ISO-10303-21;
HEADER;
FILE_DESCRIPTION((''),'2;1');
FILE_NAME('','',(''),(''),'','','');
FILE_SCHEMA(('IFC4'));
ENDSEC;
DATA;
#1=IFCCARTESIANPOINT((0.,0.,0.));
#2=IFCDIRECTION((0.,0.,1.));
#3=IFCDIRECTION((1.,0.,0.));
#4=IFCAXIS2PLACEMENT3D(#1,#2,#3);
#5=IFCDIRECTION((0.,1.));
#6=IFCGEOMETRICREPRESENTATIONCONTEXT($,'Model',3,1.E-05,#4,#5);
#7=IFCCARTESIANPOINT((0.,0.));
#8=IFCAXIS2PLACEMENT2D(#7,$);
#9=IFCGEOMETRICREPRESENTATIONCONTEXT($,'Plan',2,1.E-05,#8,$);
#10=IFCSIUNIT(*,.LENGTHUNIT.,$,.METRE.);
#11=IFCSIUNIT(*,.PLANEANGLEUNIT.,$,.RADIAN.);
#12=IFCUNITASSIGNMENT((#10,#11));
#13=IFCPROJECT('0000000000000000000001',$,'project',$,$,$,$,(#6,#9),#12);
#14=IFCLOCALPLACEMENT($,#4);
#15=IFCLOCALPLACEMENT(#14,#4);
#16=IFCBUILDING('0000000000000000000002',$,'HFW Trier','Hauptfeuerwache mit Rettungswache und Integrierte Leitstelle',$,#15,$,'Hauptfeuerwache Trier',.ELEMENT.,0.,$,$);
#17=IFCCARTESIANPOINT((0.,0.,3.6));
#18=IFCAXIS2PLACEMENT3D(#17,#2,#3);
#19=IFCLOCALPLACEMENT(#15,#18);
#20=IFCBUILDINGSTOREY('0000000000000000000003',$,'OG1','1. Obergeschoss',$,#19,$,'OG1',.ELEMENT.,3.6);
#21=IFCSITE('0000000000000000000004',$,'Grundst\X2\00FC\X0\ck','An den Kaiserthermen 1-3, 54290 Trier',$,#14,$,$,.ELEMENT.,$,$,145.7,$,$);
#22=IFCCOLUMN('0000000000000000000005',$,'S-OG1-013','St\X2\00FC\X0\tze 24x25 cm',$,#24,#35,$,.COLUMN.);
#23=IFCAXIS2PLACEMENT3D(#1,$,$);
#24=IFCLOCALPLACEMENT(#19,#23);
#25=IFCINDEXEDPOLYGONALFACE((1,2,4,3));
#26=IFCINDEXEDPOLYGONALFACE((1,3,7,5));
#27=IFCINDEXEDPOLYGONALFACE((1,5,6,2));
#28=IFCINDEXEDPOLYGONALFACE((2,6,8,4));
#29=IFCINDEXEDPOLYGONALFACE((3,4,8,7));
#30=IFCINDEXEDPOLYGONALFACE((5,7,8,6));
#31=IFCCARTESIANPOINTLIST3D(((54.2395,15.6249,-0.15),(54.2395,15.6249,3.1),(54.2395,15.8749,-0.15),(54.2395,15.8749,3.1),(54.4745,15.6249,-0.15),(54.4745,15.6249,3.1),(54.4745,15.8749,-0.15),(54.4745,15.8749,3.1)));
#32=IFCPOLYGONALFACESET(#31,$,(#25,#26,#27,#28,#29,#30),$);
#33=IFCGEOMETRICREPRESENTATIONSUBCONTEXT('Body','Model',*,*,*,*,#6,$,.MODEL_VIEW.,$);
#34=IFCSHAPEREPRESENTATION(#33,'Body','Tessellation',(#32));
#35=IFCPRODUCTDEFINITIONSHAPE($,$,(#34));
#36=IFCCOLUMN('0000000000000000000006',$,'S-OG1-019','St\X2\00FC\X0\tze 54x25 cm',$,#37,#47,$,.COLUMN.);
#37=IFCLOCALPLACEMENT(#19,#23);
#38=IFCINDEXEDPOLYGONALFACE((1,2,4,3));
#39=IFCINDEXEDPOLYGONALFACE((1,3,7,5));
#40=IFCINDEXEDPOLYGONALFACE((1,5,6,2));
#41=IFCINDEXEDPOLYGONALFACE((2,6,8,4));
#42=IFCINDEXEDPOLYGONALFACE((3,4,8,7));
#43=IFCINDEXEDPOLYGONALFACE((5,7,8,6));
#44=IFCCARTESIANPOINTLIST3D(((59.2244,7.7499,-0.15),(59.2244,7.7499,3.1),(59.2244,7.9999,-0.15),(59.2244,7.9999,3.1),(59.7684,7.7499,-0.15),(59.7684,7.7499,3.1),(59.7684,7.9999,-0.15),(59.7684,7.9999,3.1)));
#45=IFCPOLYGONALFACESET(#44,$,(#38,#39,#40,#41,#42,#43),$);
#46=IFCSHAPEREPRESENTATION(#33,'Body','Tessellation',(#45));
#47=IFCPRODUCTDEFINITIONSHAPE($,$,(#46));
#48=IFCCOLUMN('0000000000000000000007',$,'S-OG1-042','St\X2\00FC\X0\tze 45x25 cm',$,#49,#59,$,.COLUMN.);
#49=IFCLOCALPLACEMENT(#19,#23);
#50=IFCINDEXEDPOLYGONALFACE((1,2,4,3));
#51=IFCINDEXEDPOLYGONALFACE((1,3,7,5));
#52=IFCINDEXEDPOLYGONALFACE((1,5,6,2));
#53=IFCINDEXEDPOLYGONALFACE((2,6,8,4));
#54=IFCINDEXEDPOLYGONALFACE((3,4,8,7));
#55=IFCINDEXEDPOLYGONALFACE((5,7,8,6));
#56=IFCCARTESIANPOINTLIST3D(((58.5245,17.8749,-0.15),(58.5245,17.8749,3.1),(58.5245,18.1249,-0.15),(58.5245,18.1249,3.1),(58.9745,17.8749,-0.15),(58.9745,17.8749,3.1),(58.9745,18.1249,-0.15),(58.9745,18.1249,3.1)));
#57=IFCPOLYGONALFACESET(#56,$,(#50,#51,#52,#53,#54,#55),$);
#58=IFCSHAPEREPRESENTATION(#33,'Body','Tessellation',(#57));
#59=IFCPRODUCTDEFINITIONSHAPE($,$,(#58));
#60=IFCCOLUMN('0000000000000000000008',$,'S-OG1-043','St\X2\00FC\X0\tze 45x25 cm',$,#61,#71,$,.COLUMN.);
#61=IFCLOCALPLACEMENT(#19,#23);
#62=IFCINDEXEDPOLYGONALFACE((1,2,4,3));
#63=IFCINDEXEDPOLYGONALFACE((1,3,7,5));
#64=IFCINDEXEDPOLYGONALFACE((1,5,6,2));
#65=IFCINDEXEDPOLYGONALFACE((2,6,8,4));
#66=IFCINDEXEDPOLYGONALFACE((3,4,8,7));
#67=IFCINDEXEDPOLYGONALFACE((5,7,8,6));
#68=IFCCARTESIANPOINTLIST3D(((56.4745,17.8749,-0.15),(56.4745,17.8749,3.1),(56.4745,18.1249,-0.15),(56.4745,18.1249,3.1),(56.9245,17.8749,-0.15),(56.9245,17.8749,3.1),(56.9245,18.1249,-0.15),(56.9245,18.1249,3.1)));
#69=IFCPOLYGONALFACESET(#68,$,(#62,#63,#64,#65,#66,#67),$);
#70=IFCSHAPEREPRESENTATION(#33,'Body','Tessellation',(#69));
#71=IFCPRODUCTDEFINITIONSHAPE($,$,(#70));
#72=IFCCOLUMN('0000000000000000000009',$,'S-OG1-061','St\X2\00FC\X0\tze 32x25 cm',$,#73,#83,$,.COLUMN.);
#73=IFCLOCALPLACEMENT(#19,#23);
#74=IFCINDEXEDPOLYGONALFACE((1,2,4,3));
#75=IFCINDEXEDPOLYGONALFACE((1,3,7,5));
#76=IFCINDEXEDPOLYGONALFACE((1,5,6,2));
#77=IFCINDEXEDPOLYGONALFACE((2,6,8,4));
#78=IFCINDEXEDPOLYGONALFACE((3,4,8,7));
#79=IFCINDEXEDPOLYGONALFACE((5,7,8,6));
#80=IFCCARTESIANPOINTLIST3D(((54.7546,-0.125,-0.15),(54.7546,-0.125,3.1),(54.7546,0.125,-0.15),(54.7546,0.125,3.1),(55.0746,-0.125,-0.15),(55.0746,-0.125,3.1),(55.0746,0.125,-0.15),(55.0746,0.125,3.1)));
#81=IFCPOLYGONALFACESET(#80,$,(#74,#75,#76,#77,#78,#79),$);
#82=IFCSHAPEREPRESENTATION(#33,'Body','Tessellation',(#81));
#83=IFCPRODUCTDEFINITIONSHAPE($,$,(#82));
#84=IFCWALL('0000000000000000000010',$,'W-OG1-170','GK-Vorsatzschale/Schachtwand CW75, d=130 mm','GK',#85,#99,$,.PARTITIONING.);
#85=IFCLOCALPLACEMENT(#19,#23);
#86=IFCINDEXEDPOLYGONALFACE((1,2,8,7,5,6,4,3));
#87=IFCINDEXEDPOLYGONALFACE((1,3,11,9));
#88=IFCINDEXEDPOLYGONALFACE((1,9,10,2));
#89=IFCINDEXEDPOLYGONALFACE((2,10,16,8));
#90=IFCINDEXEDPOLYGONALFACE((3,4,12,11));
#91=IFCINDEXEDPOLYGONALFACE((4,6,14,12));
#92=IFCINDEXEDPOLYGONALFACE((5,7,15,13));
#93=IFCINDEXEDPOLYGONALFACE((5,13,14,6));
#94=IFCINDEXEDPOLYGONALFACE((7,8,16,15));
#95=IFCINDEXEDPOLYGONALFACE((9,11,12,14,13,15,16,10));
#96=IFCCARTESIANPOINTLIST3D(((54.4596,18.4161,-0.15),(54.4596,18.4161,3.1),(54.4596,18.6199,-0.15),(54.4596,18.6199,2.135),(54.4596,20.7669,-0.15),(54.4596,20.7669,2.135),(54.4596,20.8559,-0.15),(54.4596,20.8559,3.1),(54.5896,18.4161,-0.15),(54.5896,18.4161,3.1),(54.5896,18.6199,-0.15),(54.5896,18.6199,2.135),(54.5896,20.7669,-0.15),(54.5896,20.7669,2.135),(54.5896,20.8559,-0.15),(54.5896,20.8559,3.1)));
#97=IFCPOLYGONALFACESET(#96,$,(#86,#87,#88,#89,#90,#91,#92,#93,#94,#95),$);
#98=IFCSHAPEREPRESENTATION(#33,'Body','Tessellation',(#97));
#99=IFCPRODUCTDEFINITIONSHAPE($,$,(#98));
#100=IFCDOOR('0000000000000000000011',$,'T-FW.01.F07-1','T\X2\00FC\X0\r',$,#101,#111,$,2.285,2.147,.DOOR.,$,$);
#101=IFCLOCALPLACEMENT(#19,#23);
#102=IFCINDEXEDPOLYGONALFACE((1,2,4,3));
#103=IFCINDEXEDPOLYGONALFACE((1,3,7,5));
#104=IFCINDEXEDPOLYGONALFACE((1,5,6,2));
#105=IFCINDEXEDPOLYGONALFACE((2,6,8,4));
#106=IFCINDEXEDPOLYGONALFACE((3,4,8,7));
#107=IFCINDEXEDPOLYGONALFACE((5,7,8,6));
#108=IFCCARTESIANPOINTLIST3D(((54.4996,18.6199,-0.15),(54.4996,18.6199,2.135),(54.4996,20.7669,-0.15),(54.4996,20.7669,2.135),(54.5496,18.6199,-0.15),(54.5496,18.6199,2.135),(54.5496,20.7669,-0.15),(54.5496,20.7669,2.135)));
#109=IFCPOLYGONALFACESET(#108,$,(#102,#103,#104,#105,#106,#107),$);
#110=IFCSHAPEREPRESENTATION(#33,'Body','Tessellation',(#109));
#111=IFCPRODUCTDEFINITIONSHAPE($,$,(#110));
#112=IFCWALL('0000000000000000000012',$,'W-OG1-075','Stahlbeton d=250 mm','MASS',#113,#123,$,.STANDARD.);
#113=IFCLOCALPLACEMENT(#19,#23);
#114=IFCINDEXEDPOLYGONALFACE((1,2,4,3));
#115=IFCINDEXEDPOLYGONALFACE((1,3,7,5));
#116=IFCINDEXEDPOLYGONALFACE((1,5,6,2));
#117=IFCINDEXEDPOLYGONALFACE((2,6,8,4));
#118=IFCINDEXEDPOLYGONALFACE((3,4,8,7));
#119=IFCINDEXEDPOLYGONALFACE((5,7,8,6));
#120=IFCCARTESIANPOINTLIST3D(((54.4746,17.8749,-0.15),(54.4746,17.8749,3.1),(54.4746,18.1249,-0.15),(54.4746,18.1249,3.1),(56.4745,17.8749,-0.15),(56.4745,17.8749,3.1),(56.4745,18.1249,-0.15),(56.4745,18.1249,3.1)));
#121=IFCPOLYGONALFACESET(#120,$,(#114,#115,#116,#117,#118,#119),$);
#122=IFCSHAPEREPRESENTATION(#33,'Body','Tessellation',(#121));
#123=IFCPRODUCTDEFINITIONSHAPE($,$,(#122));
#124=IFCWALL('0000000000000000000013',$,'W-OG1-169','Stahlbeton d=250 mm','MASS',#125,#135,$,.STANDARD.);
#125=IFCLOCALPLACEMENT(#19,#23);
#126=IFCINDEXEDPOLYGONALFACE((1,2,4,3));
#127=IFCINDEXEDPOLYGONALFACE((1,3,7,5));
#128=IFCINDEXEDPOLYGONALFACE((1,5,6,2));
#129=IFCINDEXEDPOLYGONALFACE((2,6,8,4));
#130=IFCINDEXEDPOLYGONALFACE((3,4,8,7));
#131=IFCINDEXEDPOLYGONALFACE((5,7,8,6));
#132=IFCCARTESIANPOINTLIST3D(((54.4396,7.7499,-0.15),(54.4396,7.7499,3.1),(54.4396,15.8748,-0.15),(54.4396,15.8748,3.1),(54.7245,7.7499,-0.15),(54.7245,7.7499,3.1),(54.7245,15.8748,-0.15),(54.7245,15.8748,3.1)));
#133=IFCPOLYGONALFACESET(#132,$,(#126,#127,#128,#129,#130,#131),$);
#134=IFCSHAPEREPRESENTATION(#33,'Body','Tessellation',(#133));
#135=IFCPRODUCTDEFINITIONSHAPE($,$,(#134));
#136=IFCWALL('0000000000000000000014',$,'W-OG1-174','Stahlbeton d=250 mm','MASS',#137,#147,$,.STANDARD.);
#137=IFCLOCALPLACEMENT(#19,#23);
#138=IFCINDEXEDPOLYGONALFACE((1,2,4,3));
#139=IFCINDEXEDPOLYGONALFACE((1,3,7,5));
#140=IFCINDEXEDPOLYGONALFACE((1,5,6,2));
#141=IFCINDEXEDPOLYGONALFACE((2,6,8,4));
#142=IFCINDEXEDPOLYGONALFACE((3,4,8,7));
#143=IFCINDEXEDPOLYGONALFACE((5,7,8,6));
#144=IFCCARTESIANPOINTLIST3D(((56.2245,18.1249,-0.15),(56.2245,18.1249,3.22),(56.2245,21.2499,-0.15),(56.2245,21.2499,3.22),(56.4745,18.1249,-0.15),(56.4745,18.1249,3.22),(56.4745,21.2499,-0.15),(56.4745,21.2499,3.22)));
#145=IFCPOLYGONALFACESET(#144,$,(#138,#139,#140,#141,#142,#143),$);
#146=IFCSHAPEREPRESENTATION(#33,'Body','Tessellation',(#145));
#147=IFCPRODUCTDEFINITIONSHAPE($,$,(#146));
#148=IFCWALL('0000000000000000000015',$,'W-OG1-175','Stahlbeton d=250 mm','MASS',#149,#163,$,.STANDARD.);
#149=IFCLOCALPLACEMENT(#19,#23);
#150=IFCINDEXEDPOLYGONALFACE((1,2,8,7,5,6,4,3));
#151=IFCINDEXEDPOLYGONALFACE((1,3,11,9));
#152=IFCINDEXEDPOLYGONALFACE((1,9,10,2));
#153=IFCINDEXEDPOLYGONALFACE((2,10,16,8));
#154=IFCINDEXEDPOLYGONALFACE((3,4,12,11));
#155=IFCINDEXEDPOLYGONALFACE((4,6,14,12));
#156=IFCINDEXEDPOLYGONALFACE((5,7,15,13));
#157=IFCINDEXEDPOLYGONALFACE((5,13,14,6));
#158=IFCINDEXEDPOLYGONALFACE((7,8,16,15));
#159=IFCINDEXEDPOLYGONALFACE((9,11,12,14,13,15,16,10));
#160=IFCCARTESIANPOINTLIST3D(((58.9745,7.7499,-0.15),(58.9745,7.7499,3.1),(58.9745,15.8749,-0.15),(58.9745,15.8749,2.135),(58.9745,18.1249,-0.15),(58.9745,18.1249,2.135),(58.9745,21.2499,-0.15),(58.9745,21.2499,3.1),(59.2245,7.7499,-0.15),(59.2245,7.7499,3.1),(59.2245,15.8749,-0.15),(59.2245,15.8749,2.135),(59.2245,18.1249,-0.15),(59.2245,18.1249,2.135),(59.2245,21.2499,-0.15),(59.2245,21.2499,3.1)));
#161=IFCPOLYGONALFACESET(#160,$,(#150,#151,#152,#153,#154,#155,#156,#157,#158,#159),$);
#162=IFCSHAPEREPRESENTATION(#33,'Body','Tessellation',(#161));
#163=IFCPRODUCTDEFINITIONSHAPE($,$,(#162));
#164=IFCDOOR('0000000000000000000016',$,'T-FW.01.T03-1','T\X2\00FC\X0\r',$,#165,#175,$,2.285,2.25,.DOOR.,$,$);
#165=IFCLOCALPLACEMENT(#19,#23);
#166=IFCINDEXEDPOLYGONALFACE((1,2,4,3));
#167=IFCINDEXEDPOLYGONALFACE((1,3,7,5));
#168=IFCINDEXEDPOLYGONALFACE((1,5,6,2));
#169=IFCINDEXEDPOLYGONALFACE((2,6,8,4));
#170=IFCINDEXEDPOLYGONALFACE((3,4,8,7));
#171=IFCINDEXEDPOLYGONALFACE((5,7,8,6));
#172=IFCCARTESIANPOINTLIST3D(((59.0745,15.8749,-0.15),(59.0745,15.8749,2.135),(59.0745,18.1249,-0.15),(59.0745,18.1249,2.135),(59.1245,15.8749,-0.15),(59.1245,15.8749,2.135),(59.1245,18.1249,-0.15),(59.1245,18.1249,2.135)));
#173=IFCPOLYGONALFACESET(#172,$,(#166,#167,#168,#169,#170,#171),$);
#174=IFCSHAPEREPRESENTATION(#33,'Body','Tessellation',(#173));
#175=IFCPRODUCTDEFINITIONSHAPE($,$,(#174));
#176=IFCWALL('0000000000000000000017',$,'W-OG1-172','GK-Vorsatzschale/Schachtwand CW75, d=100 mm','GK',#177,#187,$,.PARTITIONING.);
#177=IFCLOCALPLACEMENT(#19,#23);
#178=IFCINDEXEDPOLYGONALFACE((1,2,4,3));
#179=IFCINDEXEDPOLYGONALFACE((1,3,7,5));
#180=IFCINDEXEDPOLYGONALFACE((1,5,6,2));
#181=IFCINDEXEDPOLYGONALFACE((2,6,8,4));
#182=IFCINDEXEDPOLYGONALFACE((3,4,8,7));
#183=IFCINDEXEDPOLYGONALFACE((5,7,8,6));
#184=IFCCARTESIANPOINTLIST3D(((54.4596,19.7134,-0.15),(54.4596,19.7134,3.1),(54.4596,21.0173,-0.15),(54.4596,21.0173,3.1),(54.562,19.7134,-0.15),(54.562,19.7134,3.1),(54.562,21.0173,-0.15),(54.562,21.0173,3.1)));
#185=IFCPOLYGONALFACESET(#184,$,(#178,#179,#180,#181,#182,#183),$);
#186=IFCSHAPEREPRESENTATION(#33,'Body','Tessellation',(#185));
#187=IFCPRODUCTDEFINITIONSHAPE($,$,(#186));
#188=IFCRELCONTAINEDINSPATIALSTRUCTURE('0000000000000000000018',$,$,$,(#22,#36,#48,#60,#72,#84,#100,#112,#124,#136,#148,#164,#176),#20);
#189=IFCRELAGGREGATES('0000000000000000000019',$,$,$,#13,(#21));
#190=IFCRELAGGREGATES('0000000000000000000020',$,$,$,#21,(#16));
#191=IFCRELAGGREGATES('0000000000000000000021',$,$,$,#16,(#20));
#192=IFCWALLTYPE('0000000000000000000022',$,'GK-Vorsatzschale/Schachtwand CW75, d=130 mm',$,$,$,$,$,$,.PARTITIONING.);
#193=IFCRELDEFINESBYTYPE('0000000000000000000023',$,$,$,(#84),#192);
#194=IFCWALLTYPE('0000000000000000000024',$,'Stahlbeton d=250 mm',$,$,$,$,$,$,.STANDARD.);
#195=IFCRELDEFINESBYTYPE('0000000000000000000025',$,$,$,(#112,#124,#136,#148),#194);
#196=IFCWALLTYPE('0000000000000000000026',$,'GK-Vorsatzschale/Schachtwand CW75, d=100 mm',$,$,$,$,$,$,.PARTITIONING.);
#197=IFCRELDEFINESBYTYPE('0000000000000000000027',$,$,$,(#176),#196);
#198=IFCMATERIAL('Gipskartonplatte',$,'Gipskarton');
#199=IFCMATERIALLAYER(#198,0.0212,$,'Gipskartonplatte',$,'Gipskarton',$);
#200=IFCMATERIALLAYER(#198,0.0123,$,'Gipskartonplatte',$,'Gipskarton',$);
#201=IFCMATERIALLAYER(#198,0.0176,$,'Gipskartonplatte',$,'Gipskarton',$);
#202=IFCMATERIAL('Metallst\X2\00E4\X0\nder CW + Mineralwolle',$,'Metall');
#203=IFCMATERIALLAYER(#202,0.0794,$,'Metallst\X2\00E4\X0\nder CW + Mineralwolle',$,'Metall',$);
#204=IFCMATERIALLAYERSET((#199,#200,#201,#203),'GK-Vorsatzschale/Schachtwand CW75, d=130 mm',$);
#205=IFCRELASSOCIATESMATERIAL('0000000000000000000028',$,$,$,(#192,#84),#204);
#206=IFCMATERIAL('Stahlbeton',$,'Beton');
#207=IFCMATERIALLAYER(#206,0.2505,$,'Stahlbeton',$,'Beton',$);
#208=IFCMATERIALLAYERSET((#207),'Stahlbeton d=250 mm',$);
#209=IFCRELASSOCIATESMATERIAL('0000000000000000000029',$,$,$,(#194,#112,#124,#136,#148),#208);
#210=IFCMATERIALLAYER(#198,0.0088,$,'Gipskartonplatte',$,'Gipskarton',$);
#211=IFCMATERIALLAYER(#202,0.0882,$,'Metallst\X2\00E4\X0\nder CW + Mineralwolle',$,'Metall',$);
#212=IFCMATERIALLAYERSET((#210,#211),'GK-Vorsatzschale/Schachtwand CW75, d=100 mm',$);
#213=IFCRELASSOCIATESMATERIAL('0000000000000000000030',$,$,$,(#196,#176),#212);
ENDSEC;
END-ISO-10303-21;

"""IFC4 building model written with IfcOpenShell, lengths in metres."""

from ifc_helpers import new_model, si_unit, direction, frame, frame_2d, origin_with_axes, origin_2d, place, context, subcontext, project, spatial, rectangle, extrude, material, layer, layer_set, layer_usage, type_object, element, fill, save


model = new_model("IFC4")

# Units and contexts
model_context = context("Model", 3, precision=1e-05, world=origin_with_axes(), true_north=direction((0.0, 1.0)))
plan_context = context("Plan", 2, precision=1e-05, world=origin_2d())
body_context = subcontext(model_context, "Body", "Model", "MODEL_VIEW")
ifc_project = project(units=[si_unit("LENGTHUNIT", "METRE"), si_unit("PLANEANGLEUNIT", "RADIAN")], contexts=[model_context, plan_context])

# Site, building, storey
site_placement = place(None, origin_with_axes())
site = spatial("IfcSite", under=ifc_project, at=site_placement, Name="Grundstück", Description="An den Kaiserthermen 1-3, 54290 Trier", CompositionType="ELEMENT", RefElevation=145.7)
building_placement = place(site_placement, origin_with_axes())
building = spatial("IfcBuilding", under=site, at=building_placement, Name="HFW Trier", Description="Hauptfeuerwache mit Rettungswache und Integrierte Leitstelle", LongName="Hauptfeuerwache Trier", CompositionType="ELEMENT", ElevationOfRefHeight=0.0)
storey_placement = place(building_placement, frame((0.0, 0.0, 3.6), z_axis=(0.0, 0.0, 1.0), x_axis=(1.0, 0.0, 0.0)))
storey = spatial("IfcBuildingStorey", under=building, at=storey_placement, Name="OG1", Description="1. Obergeschoss", LongName="OG1", CompositionType="ELEMENT", Elevation=3.6)

# Columns
column_1_placement = place(storey_placement, frame((54.2395, 15.7499, -0.15), z_axis=(0.0, 0.0, 1.0), x_axis=(1.0, 0.0, 0.0)))
element("IfcColumn", 1, at=column_1_placement, inside=storey, Name="S-OG1-013", Description="Stütze 24x25 cm", PredefinedType="COLUMN", context=body_context, shape_type="SweptSolid", body=[
    extrude(rectangle(XDim=0.235, YDim=0.25, at=frame_2d((0.1175, 0.0))), origin_with_axes(), (0.0, 0.0, 1.0), 3.25),
])
column_2_placement = place(storey_placement, frame((59.2244, 7.8749, -0.15), z_axis=(0.0, 0.0, 1.0), x_axis=(1.0, 0.0, 0.0)))
element("IfcColumn", 2, at=column_2_placement, inside=storey, Name="S-OG1-019", Description="Stütze 54x25 cm", PredefinedType="COLUMN", context=body_context, shape_type="SweptSolid", body=[
    extrude(rectangle(XDim=0.544, YDim=0.25, at=frame_2d((0.272, 0.0))), origin_with_axes(), (0.0, 0.0, 1.0), 3.25),
])
for number, where, z_axis, x_axis, name in (
    (3, (58.5245, 17.9999, -0.15), (0.0, 0.0, 1.0), (1.0, 0.0, 0.0), "S-OG1-042"),
    (4, (56.4745, 17.9999, -0.15), (0.0, 0.0, 1.0), (1.0, 0.0, 0.0), "S-OG1-043"),
):
    element("IfcColumn", number, at=place(storey_placement, frame(where, z_axis=z_axis, x_axis=x_axis)), inside=storey, Name=name, Description="Stütze 45x25 cm", PredefinedType="COLUMN", context=body_context, shape_type="SweptSolid", body=[
        extrude(rectangle(XDim=0.45, YDim=0.25, at=frame_2d((0.225, 0.0))), origin_with_axes(), (0.0, 0.0, 1.0), 3.25),
    ])
column_3_placement = place(storey_placement, frame((54.7546, 0.0, -0.15), z_axis=(0.0, 0.0, 1.0), x_axis=(1.0, 0.0, 0.0)))
element("IfcColumn", 5, at=column_3_placement, inside=storey, Name="S-OG1-061", Description="Stütze 32x25 cm", PredefinedType="COLUMN", context=body_context, shape_type="SweptSolid", body=[
    extrude(rectangle(XDim=0.32, YDim=0.25, at=frame_2d((0.16, 0.0))), origin_with_axes(), (0.0, 0.0, 1.0), 3.25),
])

# Wall, opening, door
ifc_material_1 = material(Name="Gipskartonplatte", Category="Gipskarton")
ifc_layer_1 = layer(ifc_material_1, 0.0212, Name="Gipskartonplatte", Category="Gipskarton")
ifc_layer_2 = layer(ifc_material_1, 0.0123, Name="Gipskartonplatte", Category="Gipskarton")
ifc_layer_3 = layer(ifc_material_1, 0.0176, Name="Gipskartonplatte", Category="Gipskarton")
ifc_material_2 = material(Name="Metallständer CW + Mineralwolle", Category="Metall")
ifc_layer_4 = layer(ifc_material_2, 0.0794, Name="Metallständer CW + Mineralwolle", Category="Metall")
ifc_layer_set_1 = layer_set([ifc_layer_1, ifc_layer_2, ifc_layer_3, ifc_layer_4], Name="GK-Vorsatzschale/Schachtwand CW75, d=130 mm")
ifc_layer_usage_1 = layer_usage(ifc_layer_set_1, "AXIS2", "POSITIVE", -0.065)
wall_type_1 = type_object("IfcWallType", Name="GK-Vorsatzschale/Schachtwand CW75, d=130 mm", PredefinedType="PARTITIONING", material=ifc_layer_set_1)
wall_1_placement = place(storey_placement, frame((54.5246, 20.8559, -0.15), z_axis=(0.0, 0.0, 1.0), x_axis=(0.0, -1.0, 0.0)))
wall_1 = element("IfcWall", 6, at=wall_1_placement, inside=storey, type_object=wall_type_1, material=ifc_layer_usage_1, Name="W-OG1-170", Description="GK-Vorsatzschale/Schachtwand CW75, d=130 mm", ObjectType="GK", PredefinedType="PARTITIONING", context=body_context, shape_type="SweptSolid", body=[
    extrude(rectangle(XDim=2.4398, YDim=0.13, at=frame_2d((1.2199, 0.0))), origin_with_axes(), (0.0, 0.0, 1.0), 3.25),
])
opening_1_placement = place(wall_1_placement, frame((0.089, 0.0, 0.0), z_axis=(0.0, 0.0, 1.0), x_axis=(1.0, 0.0, 0.0)))
opening_1 = element("IfcOpeningElement", 7, at=opening_1_placement, cuts=wall_1, PredefinedType="OPENING", context=body_context, shape_type="SweptSolid", body=[
    extrude(rectangle(XDim=2.147, YDim=0.23, at=frame_2d((1.0735, 0.0))), origin_with_axes(), (0.0, 0.0, 1.0), 2.285),
])
door_1_placement = place(wall_1_placement, frame((0.089, 0.0, 0.0), z_axis=(0.0, 0.0, 1.0), x_axis=(1.0, 0.0, 0.0)))
door_1 = element("IfcDoor", 8, at=door_1_placement, inside=storey, Name="T-FW.01.F07-1", Description="Tür", OverallHeight=2.285, OverallWidth=2.147, PredefinedType="DOOR", context=body_context, shape_type="SweptSolid", body=[
    extrude(rectangle(XDim=2.147, YDim=0.05, at=frame_2d((1.0735, 0.0))), origin_with_axes(), (0.0, 0.0, 1.0), 2.285),
])
fill(opening_1, door_1)

# Walls
ifc_material_3 = material(Name="Stahlbeton", Category="Beton")
ifc_layer_5 = layer(ifc_material_3, 0.2505, Name="Stahlbeton", Category="Beton")
ifc_layer_set_2 = layer_set([ifc_layer_5], Name="Stahlbeton d=250 mm")
ifc_layer_usage_2 = layer_usage(ifc_layer_set_2, "AXIS2", "POSITIVE", -0.125)
wall_type_2 = type_object("IfcWallType", Name="Stahlbeton d=250 mm", PredefinedType="STANDARD", material=ifc_layer_set_2)
wall_2_placement = place(storey_placement, frame((54.4746, 17.9999, -0.15), z_axis=(0.0, 0.0, 1.0), x_axis=(1.0, 0.0, 0.0)))
element("IfcWall", 9, at=wall_2_placement, inside=storey, type_object=wall_type_2, material=ifc_layer_usage_2, Name="W-OG1-075", Description="Stahlbeton d=250 mm", ObjectType="MASS", PredefinedType="STANDARD", context=body_context, shape_type="SweptSolid", body=[
    extrude(rectangle(XDim=1.9999, YDim=0.25, at=frame_2d((0.9999, 0.0))), origin_with_axes(), (0.0, 0.0, 1.0), 3.25),
])
ifc_layer_usage_3 = layer_usage(ifc_layer_set_2, "AXIS2", "POSITIVE", -0.1424)
wall_3_placement = place(storey_placement, frame((54.5821, 15.8748, -0.15), z_axis=(0.0, 0.0, 1.0), x_axis=(0.0, -1.0, 0.0)))
element("IfcWall", 10, at=wall_3_placement, inside=storey, type_object=wall_type_2, material=ifc_layer_usage_3, Name="W-OG1-169", Description="Stahlbeton d=250 mm", ObjectType="MASS", PredefinedType="STANDARD", context=body_context, shape_type="SweptSolid", body=[
    extrude(rectangle(XDim=8.1249, YDim=0.2849, at=frame_2d((4.0625, 0.0))), origin_with_axes(), (0.0, 0.0, 1.0), 3.25),
])
ifc_layer_usage_4 = layer_usage(ifc_layer_set_2, "AXIS2", "POSITIVE", -0.125)
wall_4_placement = place(storey_placement, frame((56.3495, 21.2499, -0.15), z_axis=(0.0, 0.0, 1.0), x_axis=(0.0, -1.0, 0.0)))
element("IfcWall", 11, at=wall_4_placement, inside=storey, type_object=wall_type_2, material=ifc_layer_usage_4, Name="W-OG1-174", Description="Stahlbeton d=250 mm", ObjectType="MASS", PredefinedType="STANDARD", context=body_context, shape_type="SweptSolid", body=[
    extrude(rectangle(XDim=3.125, YDim=0.25, at=frame_2d((1.5625, 0.0))), origin_with_axes(), (0.0, 0.0, 1.0), 3.37),
])

# Wall, opening, door
ifc_layer_usage_5 = layer_usage(ifc_layer_set_2, "AXIS2", "POSITIVE", -0.125)
wall_5_placement = place(storey_placement, frame((59.0995, 21.2499, -0.15), z_axis=(0.0, 0.0, 1.0), x_axis=(0.0, -1.0, 0.0)))
wall_5 = element("IfcWall", 12, at=wall_5_placement, inside=storey, type_object=wall_type_2, material=ifc_layer_usage_5, Name="W-OG1-175", Description="Stahlbeton d=250 mm", ObjectType="MASS", PredefinedType="STANDARD", context=body_context, shape_type="SweptSolid", body=[
    extrude(rectangle(XDim=13.5, YDim=0.25, at=frame_2d((6.75, 0.0))), origin_with_axes(), (0.0, 0.0, 1.0), 3.25),
])
opening_2_placement = place(wall_5_placement, frame((3.125, 0.0, 0.0), z_axis=(0.0, 0.0, 1.0), x_axis=(1.0, 0.0, 0.0)))
opening_2 = element("IfcOpeningElement", 13, at=opening_2_placement, cuts=wall_5, PredefinedType="OPENING", context=body_context, shape_type="SweptSolid", body=[
    extrude(rectangle(XDim=2.25, YDim=0.35, at=frame_2d((1.125, 0.0))), origin_with_axes(), (0.0, 0.0, 1.0), 2.285),
])
door_2_placement = place(wall_5_placement, frame((3.125, 0.0, 0.0), z_axis=(0.0, 0.0, 1.0), x_axis=(1.0, 0.0, 0.0)))
door_2 = element("IfcDoor", 14, at=door_2_placement, inside=storey, Name="T-FW.01.T03-1", Description="Tür", OverallHeight=2.285, OverallWidth=2.25, PredefinedType="DOOR", context=body_context, shape_type="SweptSolid", body=[
    extrude(rectangle(XDim=2.25, YDim=0.05, at=frame_2d((1.125, 0.0))), origin_with_axes(), (0.0, 0.0, 1.0), 2.285),
])
fill(opening_2, door_2)

# Wall
ifc_layer_6 = layer(ifc_material_1, 0.0088, Name="Gipskartonplatte", Category="Gipskarton")
ifc_layer_7 = layer(ifc_material_2, 0.0882, Name="Metallständer CW + Mineralwolle", Category="Metall")
ifc_layer_set_3 = layer_set([ifc_layer_6, ifc_layer_7], Name="GK-Vorsatzschale/Schachtwand CW75, d=100 mm")
ifc_layer_usage_6 = layer_usage(ifc_layer_set_3, "AXIS2", "POSITIVE", -0.0512)
wall_type_3 = type_object("IfcWallType", Name="GK-Vorsatzschale/Schachtwand CW75, d=100 mm", PredefinedType="PARTITIONING", material=ifc_layer_set_3)
wall_6_placement = place(storey_placement, frame((54.5108, 21.0173, -0.15), z_axis=(0.0, 0.0, 1.0), x_axis=(0.0, -1.0, 0.0)))
element("IfcWall", 15, at=wall_6_placement, inside=storey, type_object=wall_type_3, material=ifc_layer_usage_6, Name="W-OG1-172", Description="GK-Vorsatzschale/Schachtwand CW75, d=100 mm", ObjectType="GK", PredefinedType="PARTITIONING", context=body_context, shape_type="SweptSolid", body=[
    extrude(rectangle(XDim=1.3039, YDim=0.1024, at=frame_2d((0.6519, 0.0))), origin_with_axes(), (0.0, 0.0, 1.0), 3.25),
])

save(model, "model.ifc")
